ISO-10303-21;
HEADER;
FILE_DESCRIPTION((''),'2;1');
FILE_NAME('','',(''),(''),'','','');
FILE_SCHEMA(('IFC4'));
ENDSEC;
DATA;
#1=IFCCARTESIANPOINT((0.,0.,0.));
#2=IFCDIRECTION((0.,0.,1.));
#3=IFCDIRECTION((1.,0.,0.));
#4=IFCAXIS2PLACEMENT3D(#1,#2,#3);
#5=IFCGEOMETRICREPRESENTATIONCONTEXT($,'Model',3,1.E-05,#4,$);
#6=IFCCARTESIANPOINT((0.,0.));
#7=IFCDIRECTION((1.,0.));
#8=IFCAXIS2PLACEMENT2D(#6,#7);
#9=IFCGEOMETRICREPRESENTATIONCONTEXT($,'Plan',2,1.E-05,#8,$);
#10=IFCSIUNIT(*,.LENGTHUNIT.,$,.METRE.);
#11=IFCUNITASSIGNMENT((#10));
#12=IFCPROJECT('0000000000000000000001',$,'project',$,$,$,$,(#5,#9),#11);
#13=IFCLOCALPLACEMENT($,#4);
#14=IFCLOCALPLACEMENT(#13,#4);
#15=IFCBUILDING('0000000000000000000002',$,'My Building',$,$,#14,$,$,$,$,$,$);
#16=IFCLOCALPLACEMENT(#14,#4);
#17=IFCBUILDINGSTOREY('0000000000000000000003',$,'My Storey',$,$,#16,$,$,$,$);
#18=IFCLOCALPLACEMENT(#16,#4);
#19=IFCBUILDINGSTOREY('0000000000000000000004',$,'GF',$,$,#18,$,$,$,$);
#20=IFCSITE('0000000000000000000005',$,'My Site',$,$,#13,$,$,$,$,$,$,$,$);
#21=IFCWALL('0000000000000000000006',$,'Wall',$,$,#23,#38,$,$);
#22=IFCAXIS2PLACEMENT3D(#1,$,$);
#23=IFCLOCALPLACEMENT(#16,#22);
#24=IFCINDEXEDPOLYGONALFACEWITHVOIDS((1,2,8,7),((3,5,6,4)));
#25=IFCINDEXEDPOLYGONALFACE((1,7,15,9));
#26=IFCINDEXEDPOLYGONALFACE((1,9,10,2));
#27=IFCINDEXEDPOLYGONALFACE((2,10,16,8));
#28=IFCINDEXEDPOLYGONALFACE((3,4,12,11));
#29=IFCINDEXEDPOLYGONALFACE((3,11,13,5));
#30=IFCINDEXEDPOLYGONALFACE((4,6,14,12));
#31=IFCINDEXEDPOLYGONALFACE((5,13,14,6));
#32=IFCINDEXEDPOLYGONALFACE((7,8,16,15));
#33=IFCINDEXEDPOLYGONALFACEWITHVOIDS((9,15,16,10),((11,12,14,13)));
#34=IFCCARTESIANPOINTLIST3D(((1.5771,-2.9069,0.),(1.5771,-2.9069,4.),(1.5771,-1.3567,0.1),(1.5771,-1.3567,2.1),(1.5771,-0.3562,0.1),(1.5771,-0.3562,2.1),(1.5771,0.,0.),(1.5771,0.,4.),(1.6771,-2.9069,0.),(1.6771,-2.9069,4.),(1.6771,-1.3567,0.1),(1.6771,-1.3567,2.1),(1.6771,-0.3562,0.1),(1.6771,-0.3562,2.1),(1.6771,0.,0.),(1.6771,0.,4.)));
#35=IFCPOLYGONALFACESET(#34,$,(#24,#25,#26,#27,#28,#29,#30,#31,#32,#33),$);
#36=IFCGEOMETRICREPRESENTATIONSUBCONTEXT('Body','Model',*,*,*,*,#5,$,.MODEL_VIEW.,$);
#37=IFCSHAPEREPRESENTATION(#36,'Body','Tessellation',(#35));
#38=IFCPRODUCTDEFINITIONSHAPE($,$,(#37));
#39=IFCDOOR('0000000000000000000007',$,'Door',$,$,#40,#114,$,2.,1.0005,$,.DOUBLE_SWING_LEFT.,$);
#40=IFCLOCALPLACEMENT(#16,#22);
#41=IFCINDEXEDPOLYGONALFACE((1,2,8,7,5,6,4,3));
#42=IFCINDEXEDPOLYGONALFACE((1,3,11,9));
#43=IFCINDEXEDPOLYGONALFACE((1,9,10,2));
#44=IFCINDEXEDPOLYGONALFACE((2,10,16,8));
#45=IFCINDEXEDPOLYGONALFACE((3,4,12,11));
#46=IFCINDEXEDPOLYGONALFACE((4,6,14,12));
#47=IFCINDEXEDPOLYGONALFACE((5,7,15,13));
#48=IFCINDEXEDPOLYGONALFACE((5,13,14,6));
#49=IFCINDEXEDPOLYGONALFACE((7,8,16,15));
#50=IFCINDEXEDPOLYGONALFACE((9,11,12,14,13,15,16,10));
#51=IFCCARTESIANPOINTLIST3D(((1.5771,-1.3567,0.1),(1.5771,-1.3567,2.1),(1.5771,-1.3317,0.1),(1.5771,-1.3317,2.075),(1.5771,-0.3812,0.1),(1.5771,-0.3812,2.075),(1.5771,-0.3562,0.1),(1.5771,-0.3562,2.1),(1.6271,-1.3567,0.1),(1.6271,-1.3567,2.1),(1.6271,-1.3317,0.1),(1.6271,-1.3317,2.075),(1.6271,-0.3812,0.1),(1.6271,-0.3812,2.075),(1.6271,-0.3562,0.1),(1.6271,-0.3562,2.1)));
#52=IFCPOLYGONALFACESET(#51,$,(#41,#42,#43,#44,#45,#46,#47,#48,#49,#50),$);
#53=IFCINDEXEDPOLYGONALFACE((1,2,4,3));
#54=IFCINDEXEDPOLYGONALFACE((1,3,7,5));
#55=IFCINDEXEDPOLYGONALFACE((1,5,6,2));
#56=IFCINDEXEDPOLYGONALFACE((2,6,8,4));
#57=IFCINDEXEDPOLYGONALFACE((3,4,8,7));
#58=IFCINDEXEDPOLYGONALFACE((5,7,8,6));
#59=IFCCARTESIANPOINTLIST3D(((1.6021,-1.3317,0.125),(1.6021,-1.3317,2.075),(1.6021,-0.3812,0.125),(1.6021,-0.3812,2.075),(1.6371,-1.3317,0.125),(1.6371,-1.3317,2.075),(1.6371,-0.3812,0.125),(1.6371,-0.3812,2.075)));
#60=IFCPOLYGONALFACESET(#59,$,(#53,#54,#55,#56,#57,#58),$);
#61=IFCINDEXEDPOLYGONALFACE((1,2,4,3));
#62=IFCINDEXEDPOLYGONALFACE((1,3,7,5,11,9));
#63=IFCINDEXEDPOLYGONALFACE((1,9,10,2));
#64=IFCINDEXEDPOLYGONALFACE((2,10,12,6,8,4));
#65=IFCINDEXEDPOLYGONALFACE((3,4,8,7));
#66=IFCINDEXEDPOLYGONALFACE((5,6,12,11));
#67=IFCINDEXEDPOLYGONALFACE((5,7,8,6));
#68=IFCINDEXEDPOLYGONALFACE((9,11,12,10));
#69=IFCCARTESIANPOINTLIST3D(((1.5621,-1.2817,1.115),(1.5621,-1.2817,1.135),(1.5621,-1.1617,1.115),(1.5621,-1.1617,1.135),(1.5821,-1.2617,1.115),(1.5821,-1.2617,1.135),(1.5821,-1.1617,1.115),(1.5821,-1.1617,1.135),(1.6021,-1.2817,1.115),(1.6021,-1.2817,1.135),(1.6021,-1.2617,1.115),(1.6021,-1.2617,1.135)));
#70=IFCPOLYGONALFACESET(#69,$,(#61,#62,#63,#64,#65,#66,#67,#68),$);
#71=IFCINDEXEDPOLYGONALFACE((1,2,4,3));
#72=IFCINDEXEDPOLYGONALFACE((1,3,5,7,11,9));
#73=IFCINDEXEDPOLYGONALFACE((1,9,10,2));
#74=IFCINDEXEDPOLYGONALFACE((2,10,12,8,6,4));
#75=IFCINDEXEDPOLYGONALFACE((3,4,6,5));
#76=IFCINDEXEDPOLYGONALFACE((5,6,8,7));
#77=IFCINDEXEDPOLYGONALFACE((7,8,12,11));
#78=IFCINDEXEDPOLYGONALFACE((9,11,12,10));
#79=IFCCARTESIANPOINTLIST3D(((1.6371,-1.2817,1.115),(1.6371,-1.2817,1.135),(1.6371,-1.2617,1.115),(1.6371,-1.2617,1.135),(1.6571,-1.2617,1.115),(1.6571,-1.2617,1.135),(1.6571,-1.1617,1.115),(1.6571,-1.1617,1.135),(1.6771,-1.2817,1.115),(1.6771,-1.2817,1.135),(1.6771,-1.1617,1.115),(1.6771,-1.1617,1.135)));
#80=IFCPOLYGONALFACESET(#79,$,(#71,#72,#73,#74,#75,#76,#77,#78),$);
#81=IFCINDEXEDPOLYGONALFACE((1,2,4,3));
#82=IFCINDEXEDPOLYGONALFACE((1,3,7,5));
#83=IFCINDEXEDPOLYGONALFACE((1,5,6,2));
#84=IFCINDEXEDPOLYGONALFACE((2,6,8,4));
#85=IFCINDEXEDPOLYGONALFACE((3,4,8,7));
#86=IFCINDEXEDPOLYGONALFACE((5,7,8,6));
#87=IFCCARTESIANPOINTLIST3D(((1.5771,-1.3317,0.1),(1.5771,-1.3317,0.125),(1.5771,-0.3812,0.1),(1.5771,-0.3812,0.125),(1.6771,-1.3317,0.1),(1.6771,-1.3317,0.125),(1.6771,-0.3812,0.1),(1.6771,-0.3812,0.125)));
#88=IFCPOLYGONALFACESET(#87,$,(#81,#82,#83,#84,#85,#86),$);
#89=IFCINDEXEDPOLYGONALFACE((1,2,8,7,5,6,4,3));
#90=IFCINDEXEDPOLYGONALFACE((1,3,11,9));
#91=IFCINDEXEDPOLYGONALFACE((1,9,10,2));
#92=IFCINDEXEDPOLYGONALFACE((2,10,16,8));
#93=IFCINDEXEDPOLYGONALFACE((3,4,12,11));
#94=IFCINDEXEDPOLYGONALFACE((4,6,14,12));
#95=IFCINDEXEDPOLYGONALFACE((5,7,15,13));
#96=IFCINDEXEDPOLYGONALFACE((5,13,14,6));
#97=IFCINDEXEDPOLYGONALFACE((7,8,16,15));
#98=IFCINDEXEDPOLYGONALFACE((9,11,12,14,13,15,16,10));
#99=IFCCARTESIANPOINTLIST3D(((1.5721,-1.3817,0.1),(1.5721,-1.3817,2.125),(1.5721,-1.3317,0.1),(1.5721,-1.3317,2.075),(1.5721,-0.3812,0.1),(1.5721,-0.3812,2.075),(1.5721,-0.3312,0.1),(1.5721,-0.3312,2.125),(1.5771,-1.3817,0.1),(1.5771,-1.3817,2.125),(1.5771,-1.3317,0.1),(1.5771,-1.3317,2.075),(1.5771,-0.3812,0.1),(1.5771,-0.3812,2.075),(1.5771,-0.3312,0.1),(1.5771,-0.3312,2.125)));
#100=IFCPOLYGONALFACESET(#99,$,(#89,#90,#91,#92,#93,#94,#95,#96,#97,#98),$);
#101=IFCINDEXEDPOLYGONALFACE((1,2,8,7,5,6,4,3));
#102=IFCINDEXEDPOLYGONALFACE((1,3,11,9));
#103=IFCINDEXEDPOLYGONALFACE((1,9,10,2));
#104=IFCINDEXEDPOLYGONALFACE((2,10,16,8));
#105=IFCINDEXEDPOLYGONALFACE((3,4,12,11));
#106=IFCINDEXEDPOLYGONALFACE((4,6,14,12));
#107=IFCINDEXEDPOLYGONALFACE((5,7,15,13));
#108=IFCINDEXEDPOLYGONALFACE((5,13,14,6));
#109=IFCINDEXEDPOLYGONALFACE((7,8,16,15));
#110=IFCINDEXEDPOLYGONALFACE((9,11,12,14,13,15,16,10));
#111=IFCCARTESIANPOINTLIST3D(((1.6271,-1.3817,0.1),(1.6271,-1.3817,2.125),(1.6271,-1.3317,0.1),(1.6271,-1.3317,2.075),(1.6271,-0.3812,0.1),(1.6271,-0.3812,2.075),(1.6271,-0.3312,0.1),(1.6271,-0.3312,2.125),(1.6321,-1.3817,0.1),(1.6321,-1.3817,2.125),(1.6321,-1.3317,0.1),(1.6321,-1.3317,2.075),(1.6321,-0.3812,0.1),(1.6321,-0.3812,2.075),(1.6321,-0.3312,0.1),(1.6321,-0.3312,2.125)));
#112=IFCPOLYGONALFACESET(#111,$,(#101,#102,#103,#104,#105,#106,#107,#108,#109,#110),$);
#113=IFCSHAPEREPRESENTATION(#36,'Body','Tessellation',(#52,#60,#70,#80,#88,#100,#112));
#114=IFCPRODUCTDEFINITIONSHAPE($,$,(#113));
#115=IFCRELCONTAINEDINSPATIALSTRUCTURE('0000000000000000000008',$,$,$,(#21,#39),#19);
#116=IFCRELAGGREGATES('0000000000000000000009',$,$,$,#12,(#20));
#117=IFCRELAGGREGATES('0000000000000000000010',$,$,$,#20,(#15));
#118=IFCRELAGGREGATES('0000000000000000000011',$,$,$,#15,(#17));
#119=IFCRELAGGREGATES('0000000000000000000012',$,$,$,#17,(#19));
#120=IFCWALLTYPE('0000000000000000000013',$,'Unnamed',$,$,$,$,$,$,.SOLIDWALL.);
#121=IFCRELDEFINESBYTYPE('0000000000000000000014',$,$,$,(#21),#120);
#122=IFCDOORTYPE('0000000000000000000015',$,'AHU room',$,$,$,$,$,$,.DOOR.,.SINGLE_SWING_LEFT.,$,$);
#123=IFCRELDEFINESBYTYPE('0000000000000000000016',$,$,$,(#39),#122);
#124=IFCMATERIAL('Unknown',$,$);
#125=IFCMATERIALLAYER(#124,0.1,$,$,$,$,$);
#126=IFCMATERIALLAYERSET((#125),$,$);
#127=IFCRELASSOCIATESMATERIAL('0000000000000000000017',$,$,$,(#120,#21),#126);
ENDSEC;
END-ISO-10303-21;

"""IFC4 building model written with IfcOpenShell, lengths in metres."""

from ifc_helpers import new_model, entity, si_unit, frame, origin_with_axes, origin_2d_with_axis, place, context, subcontext, project, spatial, line, indexed_curve, outline, extrude, shape, source, transform, mapped, material, layer, layer_set, layer_usage, type_object, type_shapes, element, fill, save


model = new_model("IFC4")

# Units and contexts
model_context = context("Model", 3, precision=1e-05, world=origin_with_axes())
plan_context = context("Plan", 2, precision=1e-05, world=origin_2d_with_axis())
body_context_1 = subcontext(model_context, "Body", "Model", "MODEL_VIEW")
body_context_2 = subcontext(plan_context, "Body", "Plan", "PLAN_VIEW")
ifc_project = project(units=[si_unit("LENGTHUNIT", "METRE")], contexts=[model_context, plan_context])

# Site, building, storeys
site_placement = place(None, origin_with_axes())
site = spatial("IfcSite", under=ifc_project, at=site_placement, Name="My Site")
building_placement = place(site_placement, origin_with_axes())
building = spatial("IfcBuilding", under=site, at=building_placement, Name="My Building")
storey_1_placement = place(building_placement, origin_with_axes())
storey_1 = spatial("IfcBuildingStorey", under=building, at=storey_1_placement, Name="My Storey")
storey_2_placement = place(storey_1_placement, origin_with_axes())
storey_2 = spatial("IfcBuildingStorey", under=storey_1, at=storey_2_placement, Name="GF")

# Shared definitions
ifc_material = material(Name="Unknown")

# Shared definitions
ifc_layer_1 = layer(ifc_material, 0.1)
ifc_layer_set_1 = layer_set([ifc_layer_1])
wall_type = type_object("IfcWallType", Name="Unnamed", PredefinedType="SOLIDWALL", material=ifc_layer_set_1)

# Wall, opening, door
ifc_layer_usage_1 = layer_usage(ifc_layer_set_1, "AXIS2", "POSITIVE", 0.0)
wall_1_placement = place(storey_2_placement, frame((1.5771, 0.0, 0.0), z_axis=(0.0, 0.0, 1.0), x_axis=(0.0, -1.0, 0.0)))
wall_1 = element("IfcWall", 1, at=wall_1_placement, inside=storey_2, type_object=wall_type, material=ifc_layer_usage_1, Name="Wall", context=body_context_1, shape_type="SweptSolid", body=[
    extrude(outline(indexed_curve([(0.0, 0.0), (0.0, 0.1), (2.9069, 0.1), (2.9069, 0.0)], segments=[line(1, 2, 3, 4, 1)])), origin_with_axes(), (0.0, 0.0, 1.0), 4.0),
])
shared_shape_1 = source(origin_with_axes(), body_context_1, "Body", "SweptSolid", [
    extrude(outline(indexed_curve([(0.0, 0.0), (1.0005, 0.0), (1.0005, 2.0), (0.0, 2.0)], segments=[line(1, 2, 3, 4, 1)])), frame((0.0, -0.6, 0.0), z_axis=(0.0, -1.0, 0.0), x_axis=(1.0, 0.0, 0.0)), (0.0, 0.0, -1.0), 1.2),
])
opening_1_placement = place(wall_1_placement, frame((0.3562, 0.0, 0.1), z_axis=(0.0, 0.0, 1.0), x_axis=(1.0, 0.0, 0.0)))
opening_1 = element("IfcOpeningElement", 2, at=opening_1_placement, cuts=wall_1, PredefinedType="OPENING", context=body_context_1, shape_type="MappedRepresentation", body=[
    mapped(shared_shape_1, transform((0.0, 0.0, 0.0), x_axis=(1.0, 0.0, 0.0), y_axis=(0.0, 1.0, 0.0), z_axis=(0.0, 0.0, 1.0), scale=1.0)),
])
door_type_1 = type_object("IfcDoorType", Name="AHU room", OperationType="SINGLE_SWING_LEFT", PredefinedType="DOOR")
shared_shape_2 = source(origin_with_axes(), body_context_1, "Body", "SweptSolid", [
    extrude(outline(indexed_curve([(0.0, 0.0), (0.0, 2.0), (1.0005, 2.0), (1.0005, 0.0), (0.9755, 0.0), (0.9755, 1.975), (0.025, 1.975), (0.025, 0.0)], segments=[line(1, 2, 3, 4, 5, 6, 7, 8, 1)])), frame((0.0, 0.0, 0.0), z_axis=(0.0, -1.0, 0.0), x_axis=(1.0, 0.0, 0.0)), (0.0, 0.0, -1.0), 0.05),
    extrude(outline(indexed_curve([(0.0, 0.0), (0.9505, 0.0), (0.9505, 0.035), (0.0, 0.035)], segments=[line(1, 2, 3, 4, 1)])), frame((0.025, 0.025, 0.025), z_axis=(0.0, 0.0, 1.0), x_axis=(1.0, 0.0, 0.0)), (0.0, 0.0, 1.0), 1.95),
    extrude(outline(indexed_curve([(0.0, 0.0), (0.0, -0.04), (-0.12, -0.04), (-0.12, -0.02), (-0.02, -0.02), (-0.02, 0.0)], segments=[line(1, 2, 3, 4, 5, 6, 1)])), frame((0.9255, 0.025, 1.015), z_axis=(0.0, 0.0, 1.0), x_axis=(1.0, 0.0, 0.0)), (0.0, 0.0, 1.0), 0.02),
    extrude(outline(indexed_curve([(0.0, 0.0), (0.0, 0.04), (-0.12, 0.04), (-0.12, 0.02), (-0.02, 0.02), (-0.02, 0.0)], segments=[line(1, 2, 3, 4, 5, 6, 1)])), frame((0.9255, 0.06, 1.015), z_axis=(0.0, 0.0, 1.0), x_axis=(1.0, 0.0, 0.0)), (0.0, 0.0, 1.0), 0.02),
    extrude(outline(indexed_curve([(0.0, 0.0), (0.9505, 0.0), (0.9505, 0.1), (0.0, 0.1)], segments=[line(1, 2, 3, 4, 1)])), frame((0.025, 0.0, 0.0), z_axis=(0.0, 0.0, 1.0), x_axis=(1.0, 0.0, 0.0)), (0.0, 0.0, 1.0), 0.025),
    extrude(outline(indexed_curve([(0.0, 0.0), (0.0, 2.025), (1.0505, 2.025), (1.0505, 0.0), (1.0005, 0.0), (1.0005, 1.975), (0.05, 1.975), (0.05, 0.0)], segments=[line(1, 2, 3, 4, 5, 6, 7, 8, 1)])), frame((-0.025, -0.005, 0.0), z_axis=(0.0, -1.0, 0.0), x_axis=(1.0, 0.0, 0.0)), (0.0, 0.0, -1.0), 0.005),
    extrude(outline(indexed_curve([(0.0, 0.0), (0.0, 2.025), (1.0505, 2.025), (1.0505, 0.0), (1.0005, 0.0), (1.0005, 1.975), (0.05, 1.975), (0.05, 0.0)], segments=[line(1, 2, 3, 4, 5, 6, 7, 8, 1)])), frame((-0.025, 0.05, 0.0), z_axis=(0.0, -1.0, 0.0), x_axis=(1.0, 0.0, 0.0)), (0.0, 0.0, -1.0), 0.005),
])
shared_shape_3 = source(origin_with_axes(), body_context_2, "Body", "Curve2D", [
    entity("IfcIndexedPolyCurve", entity("IfcCartesianPointList2D", [[0.0, 0.0], [0.025, 0.0], [0.025, 0.05], [0.0, 0.05]]), [entity("IfcLineIndex", [1, 2, 3, 4, 1])]),
    entity("IfcIndexedPolyCurve", entity("IfcCartesianPointList2D", [[1.0005, 0.0], [0.9755, 0.0], [0.9755, 0.05], [1.0005, 0.05]]), [entity("IfcLineIndex", [1, 2, 3, 4, 1])]),
    entity("IfcIndexedPolyCurve", entity("IfcCartesianPointList2D", [[0.025, 0.05], [0.025, -0.9005], [0.06, -0.9005]])),
    entity("IfcTrimmedCurve", entity("IfcEllipse", entity("IfcAxis2Placement2D", entity("IfcCartesianPoint", [0.06, 0.05]), entity("IfcDirection", [1.0, 0.0])), 0.9155, 0.9505), [entity("IfcCartesianPoint", [0.06, -0.9005])], [entity("IfcCartesianPoint", [0.06, 1.0005])], True, "CARTESIAN"),
    entity("IfcIndexedPolyCurve", entity("IfcCartesianPointList2D", [[0.025, 0.05], [0.06, 0.05], [0.06, 1.0005], [0.025, 1.0005]]), [entity("IfcLineIndex", [1, 2, 3, 4, 1])]),
])
type_shapes(door_type_1, [shared_shape_2, shared_shape_3])
door_1_placement = place(opening_1_placement, frame((0.0, 0.0, 0.0), z_axis=(0.0, 0.0, 1.0), x_axis=(1.0, 0.0, 0.0)))
door_1 = element("IfcDoor", 3, at=door_1_placement, inside=storey_2, type_object=door_type_1, Name="Door", OperationType="DOUBLE_SWING_LEFT", OverallHeight=2.0, OverallWidth=1.0005, shapes=[
    shape(body_context_1, "Body", "MappedRepresentation", [mapped(shared_shape_2, transform((0.0, 0.0, 0.0), x_axis=(1.0, 0.0, 0.0), y_axis=(0.0, 1.0, 0.0), z_axis=(0.0, 0.0, 1.0), scale=1.0))]),
    shape(body_context_2, "Body", "MappedRepresentation", [mapped(shared_shape_3, transform((0.0, 0.0, 0.0), x_axis=(1.0, 0.0, 0.0), y_axis=(0.0, 1.0, 0.0), z_axis=(0.0, 0.0, 1.0), scale=1.0))]),
])
fill(opening_1, door_1)

save(model, "model.ifc")
